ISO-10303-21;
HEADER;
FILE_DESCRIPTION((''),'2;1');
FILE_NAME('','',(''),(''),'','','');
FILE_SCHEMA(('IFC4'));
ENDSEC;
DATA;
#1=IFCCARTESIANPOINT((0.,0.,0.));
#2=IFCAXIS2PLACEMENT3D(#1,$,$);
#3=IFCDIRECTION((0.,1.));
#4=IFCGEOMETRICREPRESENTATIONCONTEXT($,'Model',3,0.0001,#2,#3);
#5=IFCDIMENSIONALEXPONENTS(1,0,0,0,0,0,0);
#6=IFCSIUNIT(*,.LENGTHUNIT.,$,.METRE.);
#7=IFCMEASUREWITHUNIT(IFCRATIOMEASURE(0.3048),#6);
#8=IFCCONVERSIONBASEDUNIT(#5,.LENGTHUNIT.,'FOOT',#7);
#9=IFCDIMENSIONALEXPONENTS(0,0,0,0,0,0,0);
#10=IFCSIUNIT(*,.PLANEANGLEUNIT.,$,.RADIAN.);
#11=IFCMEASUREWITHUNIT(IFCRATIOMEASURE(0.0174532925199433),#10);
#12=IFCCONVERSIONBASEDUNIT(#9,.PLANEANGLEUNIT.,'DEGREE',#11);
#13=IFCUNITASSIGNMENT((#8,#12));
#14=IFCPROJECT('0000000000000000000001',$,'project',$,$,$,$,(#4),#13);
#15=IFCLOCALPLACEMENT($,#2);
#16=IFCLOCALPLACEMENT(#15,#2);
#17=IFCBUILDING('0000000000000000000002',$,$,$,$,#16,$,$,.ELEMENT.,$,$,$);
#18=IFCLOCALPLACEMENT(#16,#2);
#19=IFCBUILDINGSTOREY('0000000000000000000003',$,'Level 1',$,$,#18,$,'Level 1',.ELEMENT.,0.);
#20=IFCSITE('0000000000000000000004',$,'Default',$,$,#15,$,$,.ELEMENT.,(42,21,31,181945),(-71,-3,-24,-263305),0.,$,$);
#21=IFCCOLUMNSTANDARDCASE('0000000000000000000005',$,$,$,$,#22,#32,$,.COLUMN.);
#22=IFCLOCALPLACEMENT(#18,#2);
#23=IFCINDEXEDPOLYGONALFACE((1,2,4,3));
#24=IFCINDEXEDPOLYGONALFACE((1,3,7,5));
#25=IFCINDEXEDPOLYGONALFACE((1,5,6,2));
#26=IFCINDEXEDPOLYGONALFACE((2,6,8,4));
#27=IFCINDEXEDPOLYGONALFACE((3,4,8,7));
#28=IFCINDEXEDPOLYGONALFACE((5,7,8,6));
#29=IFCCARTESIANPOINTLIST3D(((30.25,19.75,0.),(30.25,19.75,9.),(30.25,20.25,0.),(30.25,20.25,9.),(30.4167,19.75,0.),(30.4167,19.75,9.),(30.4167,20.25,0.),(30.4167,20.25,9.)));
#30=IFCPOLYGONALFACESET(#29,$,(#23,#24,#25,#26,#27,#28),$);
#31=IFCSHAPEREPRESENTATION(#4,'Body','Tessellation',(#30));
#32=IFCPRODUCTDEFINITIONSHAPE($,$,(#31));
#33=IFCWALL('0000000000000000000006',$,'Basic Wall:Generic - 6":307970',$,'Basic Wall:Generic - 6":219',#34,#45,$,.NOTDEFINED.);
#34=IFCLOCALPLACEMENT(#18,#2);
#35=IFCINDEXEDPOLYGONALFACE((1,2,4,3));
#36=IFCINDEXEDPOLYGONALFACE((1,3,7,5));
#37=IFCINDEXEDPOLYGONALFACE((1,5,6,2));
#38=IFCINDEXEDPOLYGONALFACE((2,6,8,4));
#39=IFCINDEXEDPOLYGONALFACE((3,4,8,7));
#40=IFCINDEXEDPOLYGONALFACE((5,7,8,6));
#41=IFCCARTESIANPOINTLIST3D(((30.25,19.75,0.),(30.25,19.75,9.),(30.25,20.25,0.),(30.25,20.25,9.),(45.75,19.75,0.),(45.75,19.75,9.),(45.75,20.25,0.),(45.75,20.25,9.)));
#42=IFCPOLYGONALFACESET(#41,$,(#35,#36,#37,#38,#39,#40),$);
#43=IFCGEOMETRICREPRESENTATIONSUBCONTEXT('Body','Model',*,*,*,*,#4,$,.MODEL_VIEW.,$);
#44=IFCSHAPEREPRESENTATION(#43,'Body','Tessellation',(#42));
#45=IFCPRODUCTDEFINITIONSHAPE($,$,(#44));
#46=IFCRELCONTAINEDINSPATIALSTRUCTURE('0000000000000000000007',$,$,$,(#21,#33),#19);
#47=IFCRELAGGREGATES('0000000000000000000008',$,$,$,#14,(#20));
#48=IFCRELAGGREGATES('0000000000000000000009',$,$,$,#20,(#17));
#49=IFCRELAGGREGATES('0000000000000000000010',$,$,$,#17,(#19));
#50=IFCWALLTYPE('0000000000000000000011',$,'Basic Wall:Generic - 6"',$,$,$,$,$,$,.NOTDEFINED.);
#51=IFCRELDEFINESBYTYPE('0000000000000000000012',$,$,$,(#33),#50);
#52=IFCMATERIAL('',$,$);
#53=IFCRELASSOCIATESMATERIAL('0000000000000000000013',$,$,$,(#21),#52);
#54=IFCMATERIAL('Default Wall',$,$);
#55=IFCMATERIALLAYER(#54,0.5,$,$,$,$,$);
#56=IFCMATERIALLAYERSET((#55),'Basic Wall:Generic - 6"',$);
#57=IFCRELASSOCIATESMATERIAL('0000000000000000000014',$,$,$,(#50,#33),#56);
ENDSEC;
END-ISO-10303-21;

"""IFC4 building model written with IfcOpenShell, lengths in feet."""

from ifc_helpers import new_model, entity, si_unit, converted_unit, direction, frame, frame_2d, origin, place, context, subcontext, project, spatial, polyline, rectangle, extrude, clip, bounded_halfspace, material, layer, layer_set, layer_usage, type_object, element, save


model = new_model("IFC4")

# Units and contexts
model_context = context("Model", 3, precision=0.0001, world=origin(), true_north=direction((0.0, 1.0)))
body_context = subcontext(model_context, "Body", "Model", "MODEL_VIEW")
ifc_project = project(units=[converted_unit("LENGTHUNIT", "FOOT", entity("IfcRatioMeasure", 0.3048), si_unit("LENGTHUNIT", "METRE"), dimensions=[1, 0, 0, 0, 0, 0, 0]), converted_unit("PLANEANGLEUNIT", "DEGREE", entity("IfcRatioMeasure", 0.0174532925199433), si_unit("PLANEANGLEUNIT", "RADIAN"), dimensions=[0, 0, 0, 0, 0, 0, 0])], contexts=[model_context])

# Site, building, storey
site_placement = place(None, origin())
site = spatial("IfcSite", under=ifc_project, at=site_placement, Name="Default", CompositionType="ELEMENT", RefLatitude=(42, 21, 31, 181945), RefLongitude=(-71, -3, -24, -263305), RefElevation=0.0)
building_placement = place(site_placement, origin())
building = spatial("IfcBuilding", under=site, at=building_placement, CompositionType="ELEMENT")
storey_placement = place(building_placement, origin())
storey = spatial("IfcBuildingStorey", under=building, at=storey_placement, Name="Level 1", LongName="Level 1", CompositionType="ELEMENT", Elevation=0.0)

# Column
ifc_material_1 = material(Name="")
wall_placement = place(storey_placement, frame((30.25, 20.0, 0.0)))
for number, where, z_axis, x_axis in (
    (1, (0.0833, 0.0, 0.0), (0.0, 0.0, 1.0), (1.0, 0.0, 0.0)),
):
    element("IfcColumnStandardCase", number, at=place(wall_placement, frame(where, z_axis=z_axis, x_axis=x_axis)), inside=storey, material=ifc_material_1, PredefinedType="COLUMN", context=model_context, shape_type="SweptSolid", body=[
        extrude(rectangle(XDim=0.1667, YDim=0.5), origin(), (0.0, 0.0, 1.0), 9.0),
    ])

# Wall
ifc_material_2 = material(Name="Default Wall")
ifc_layer = layer(ifc_material_2, 0.5)
ifc_layer_set = layer_set([ifc_layer], Name="Basic Wall:Generic - 6\"")
ifc_layer_usage = layer_usage(ifc_layer_set, "AXIS2", "NEGATIVE", 0.25)
wall_type = type_object("IfcWallType", Name="Basic Wall:Generic - 6\"", PredefinedType="NOTDEFINED", material=ifc_layer_set)
element("IfcWall", 2, at=wall_placement, inside=storey, type_object=wall_type, material=ifc_layer_usage, Name="Basic Wall:Generic - 6\":307970", ObjectType="Basic Wall:Generic - 6\":219", PredefinedType="NOTDEFINED", context=body_context, shape_type="Clipping", body=[
    clip(extrude(rectangle(XDim=15.5, YDim=0.5, at=frame_2d((7.75, 0.0), x_axis=(-1.0, 0.0))), origin(), (0.0, 0.0, 1.0), 9.0), bounded_halfspace(frame((0.0, -0.25, 9.0), z_axis=(0.0, 0.0, -1.0), x_axis=(1.0, 0.0, 0.0)), True, frame((0.0, -0.25, 9.0)), polyline([(0.0, 0.0), (15.5, 0.0), (15.5, 0.5), (0.0, 0.5), (0.0, 0.0)]))),
])

save(model, "model.ifc")
